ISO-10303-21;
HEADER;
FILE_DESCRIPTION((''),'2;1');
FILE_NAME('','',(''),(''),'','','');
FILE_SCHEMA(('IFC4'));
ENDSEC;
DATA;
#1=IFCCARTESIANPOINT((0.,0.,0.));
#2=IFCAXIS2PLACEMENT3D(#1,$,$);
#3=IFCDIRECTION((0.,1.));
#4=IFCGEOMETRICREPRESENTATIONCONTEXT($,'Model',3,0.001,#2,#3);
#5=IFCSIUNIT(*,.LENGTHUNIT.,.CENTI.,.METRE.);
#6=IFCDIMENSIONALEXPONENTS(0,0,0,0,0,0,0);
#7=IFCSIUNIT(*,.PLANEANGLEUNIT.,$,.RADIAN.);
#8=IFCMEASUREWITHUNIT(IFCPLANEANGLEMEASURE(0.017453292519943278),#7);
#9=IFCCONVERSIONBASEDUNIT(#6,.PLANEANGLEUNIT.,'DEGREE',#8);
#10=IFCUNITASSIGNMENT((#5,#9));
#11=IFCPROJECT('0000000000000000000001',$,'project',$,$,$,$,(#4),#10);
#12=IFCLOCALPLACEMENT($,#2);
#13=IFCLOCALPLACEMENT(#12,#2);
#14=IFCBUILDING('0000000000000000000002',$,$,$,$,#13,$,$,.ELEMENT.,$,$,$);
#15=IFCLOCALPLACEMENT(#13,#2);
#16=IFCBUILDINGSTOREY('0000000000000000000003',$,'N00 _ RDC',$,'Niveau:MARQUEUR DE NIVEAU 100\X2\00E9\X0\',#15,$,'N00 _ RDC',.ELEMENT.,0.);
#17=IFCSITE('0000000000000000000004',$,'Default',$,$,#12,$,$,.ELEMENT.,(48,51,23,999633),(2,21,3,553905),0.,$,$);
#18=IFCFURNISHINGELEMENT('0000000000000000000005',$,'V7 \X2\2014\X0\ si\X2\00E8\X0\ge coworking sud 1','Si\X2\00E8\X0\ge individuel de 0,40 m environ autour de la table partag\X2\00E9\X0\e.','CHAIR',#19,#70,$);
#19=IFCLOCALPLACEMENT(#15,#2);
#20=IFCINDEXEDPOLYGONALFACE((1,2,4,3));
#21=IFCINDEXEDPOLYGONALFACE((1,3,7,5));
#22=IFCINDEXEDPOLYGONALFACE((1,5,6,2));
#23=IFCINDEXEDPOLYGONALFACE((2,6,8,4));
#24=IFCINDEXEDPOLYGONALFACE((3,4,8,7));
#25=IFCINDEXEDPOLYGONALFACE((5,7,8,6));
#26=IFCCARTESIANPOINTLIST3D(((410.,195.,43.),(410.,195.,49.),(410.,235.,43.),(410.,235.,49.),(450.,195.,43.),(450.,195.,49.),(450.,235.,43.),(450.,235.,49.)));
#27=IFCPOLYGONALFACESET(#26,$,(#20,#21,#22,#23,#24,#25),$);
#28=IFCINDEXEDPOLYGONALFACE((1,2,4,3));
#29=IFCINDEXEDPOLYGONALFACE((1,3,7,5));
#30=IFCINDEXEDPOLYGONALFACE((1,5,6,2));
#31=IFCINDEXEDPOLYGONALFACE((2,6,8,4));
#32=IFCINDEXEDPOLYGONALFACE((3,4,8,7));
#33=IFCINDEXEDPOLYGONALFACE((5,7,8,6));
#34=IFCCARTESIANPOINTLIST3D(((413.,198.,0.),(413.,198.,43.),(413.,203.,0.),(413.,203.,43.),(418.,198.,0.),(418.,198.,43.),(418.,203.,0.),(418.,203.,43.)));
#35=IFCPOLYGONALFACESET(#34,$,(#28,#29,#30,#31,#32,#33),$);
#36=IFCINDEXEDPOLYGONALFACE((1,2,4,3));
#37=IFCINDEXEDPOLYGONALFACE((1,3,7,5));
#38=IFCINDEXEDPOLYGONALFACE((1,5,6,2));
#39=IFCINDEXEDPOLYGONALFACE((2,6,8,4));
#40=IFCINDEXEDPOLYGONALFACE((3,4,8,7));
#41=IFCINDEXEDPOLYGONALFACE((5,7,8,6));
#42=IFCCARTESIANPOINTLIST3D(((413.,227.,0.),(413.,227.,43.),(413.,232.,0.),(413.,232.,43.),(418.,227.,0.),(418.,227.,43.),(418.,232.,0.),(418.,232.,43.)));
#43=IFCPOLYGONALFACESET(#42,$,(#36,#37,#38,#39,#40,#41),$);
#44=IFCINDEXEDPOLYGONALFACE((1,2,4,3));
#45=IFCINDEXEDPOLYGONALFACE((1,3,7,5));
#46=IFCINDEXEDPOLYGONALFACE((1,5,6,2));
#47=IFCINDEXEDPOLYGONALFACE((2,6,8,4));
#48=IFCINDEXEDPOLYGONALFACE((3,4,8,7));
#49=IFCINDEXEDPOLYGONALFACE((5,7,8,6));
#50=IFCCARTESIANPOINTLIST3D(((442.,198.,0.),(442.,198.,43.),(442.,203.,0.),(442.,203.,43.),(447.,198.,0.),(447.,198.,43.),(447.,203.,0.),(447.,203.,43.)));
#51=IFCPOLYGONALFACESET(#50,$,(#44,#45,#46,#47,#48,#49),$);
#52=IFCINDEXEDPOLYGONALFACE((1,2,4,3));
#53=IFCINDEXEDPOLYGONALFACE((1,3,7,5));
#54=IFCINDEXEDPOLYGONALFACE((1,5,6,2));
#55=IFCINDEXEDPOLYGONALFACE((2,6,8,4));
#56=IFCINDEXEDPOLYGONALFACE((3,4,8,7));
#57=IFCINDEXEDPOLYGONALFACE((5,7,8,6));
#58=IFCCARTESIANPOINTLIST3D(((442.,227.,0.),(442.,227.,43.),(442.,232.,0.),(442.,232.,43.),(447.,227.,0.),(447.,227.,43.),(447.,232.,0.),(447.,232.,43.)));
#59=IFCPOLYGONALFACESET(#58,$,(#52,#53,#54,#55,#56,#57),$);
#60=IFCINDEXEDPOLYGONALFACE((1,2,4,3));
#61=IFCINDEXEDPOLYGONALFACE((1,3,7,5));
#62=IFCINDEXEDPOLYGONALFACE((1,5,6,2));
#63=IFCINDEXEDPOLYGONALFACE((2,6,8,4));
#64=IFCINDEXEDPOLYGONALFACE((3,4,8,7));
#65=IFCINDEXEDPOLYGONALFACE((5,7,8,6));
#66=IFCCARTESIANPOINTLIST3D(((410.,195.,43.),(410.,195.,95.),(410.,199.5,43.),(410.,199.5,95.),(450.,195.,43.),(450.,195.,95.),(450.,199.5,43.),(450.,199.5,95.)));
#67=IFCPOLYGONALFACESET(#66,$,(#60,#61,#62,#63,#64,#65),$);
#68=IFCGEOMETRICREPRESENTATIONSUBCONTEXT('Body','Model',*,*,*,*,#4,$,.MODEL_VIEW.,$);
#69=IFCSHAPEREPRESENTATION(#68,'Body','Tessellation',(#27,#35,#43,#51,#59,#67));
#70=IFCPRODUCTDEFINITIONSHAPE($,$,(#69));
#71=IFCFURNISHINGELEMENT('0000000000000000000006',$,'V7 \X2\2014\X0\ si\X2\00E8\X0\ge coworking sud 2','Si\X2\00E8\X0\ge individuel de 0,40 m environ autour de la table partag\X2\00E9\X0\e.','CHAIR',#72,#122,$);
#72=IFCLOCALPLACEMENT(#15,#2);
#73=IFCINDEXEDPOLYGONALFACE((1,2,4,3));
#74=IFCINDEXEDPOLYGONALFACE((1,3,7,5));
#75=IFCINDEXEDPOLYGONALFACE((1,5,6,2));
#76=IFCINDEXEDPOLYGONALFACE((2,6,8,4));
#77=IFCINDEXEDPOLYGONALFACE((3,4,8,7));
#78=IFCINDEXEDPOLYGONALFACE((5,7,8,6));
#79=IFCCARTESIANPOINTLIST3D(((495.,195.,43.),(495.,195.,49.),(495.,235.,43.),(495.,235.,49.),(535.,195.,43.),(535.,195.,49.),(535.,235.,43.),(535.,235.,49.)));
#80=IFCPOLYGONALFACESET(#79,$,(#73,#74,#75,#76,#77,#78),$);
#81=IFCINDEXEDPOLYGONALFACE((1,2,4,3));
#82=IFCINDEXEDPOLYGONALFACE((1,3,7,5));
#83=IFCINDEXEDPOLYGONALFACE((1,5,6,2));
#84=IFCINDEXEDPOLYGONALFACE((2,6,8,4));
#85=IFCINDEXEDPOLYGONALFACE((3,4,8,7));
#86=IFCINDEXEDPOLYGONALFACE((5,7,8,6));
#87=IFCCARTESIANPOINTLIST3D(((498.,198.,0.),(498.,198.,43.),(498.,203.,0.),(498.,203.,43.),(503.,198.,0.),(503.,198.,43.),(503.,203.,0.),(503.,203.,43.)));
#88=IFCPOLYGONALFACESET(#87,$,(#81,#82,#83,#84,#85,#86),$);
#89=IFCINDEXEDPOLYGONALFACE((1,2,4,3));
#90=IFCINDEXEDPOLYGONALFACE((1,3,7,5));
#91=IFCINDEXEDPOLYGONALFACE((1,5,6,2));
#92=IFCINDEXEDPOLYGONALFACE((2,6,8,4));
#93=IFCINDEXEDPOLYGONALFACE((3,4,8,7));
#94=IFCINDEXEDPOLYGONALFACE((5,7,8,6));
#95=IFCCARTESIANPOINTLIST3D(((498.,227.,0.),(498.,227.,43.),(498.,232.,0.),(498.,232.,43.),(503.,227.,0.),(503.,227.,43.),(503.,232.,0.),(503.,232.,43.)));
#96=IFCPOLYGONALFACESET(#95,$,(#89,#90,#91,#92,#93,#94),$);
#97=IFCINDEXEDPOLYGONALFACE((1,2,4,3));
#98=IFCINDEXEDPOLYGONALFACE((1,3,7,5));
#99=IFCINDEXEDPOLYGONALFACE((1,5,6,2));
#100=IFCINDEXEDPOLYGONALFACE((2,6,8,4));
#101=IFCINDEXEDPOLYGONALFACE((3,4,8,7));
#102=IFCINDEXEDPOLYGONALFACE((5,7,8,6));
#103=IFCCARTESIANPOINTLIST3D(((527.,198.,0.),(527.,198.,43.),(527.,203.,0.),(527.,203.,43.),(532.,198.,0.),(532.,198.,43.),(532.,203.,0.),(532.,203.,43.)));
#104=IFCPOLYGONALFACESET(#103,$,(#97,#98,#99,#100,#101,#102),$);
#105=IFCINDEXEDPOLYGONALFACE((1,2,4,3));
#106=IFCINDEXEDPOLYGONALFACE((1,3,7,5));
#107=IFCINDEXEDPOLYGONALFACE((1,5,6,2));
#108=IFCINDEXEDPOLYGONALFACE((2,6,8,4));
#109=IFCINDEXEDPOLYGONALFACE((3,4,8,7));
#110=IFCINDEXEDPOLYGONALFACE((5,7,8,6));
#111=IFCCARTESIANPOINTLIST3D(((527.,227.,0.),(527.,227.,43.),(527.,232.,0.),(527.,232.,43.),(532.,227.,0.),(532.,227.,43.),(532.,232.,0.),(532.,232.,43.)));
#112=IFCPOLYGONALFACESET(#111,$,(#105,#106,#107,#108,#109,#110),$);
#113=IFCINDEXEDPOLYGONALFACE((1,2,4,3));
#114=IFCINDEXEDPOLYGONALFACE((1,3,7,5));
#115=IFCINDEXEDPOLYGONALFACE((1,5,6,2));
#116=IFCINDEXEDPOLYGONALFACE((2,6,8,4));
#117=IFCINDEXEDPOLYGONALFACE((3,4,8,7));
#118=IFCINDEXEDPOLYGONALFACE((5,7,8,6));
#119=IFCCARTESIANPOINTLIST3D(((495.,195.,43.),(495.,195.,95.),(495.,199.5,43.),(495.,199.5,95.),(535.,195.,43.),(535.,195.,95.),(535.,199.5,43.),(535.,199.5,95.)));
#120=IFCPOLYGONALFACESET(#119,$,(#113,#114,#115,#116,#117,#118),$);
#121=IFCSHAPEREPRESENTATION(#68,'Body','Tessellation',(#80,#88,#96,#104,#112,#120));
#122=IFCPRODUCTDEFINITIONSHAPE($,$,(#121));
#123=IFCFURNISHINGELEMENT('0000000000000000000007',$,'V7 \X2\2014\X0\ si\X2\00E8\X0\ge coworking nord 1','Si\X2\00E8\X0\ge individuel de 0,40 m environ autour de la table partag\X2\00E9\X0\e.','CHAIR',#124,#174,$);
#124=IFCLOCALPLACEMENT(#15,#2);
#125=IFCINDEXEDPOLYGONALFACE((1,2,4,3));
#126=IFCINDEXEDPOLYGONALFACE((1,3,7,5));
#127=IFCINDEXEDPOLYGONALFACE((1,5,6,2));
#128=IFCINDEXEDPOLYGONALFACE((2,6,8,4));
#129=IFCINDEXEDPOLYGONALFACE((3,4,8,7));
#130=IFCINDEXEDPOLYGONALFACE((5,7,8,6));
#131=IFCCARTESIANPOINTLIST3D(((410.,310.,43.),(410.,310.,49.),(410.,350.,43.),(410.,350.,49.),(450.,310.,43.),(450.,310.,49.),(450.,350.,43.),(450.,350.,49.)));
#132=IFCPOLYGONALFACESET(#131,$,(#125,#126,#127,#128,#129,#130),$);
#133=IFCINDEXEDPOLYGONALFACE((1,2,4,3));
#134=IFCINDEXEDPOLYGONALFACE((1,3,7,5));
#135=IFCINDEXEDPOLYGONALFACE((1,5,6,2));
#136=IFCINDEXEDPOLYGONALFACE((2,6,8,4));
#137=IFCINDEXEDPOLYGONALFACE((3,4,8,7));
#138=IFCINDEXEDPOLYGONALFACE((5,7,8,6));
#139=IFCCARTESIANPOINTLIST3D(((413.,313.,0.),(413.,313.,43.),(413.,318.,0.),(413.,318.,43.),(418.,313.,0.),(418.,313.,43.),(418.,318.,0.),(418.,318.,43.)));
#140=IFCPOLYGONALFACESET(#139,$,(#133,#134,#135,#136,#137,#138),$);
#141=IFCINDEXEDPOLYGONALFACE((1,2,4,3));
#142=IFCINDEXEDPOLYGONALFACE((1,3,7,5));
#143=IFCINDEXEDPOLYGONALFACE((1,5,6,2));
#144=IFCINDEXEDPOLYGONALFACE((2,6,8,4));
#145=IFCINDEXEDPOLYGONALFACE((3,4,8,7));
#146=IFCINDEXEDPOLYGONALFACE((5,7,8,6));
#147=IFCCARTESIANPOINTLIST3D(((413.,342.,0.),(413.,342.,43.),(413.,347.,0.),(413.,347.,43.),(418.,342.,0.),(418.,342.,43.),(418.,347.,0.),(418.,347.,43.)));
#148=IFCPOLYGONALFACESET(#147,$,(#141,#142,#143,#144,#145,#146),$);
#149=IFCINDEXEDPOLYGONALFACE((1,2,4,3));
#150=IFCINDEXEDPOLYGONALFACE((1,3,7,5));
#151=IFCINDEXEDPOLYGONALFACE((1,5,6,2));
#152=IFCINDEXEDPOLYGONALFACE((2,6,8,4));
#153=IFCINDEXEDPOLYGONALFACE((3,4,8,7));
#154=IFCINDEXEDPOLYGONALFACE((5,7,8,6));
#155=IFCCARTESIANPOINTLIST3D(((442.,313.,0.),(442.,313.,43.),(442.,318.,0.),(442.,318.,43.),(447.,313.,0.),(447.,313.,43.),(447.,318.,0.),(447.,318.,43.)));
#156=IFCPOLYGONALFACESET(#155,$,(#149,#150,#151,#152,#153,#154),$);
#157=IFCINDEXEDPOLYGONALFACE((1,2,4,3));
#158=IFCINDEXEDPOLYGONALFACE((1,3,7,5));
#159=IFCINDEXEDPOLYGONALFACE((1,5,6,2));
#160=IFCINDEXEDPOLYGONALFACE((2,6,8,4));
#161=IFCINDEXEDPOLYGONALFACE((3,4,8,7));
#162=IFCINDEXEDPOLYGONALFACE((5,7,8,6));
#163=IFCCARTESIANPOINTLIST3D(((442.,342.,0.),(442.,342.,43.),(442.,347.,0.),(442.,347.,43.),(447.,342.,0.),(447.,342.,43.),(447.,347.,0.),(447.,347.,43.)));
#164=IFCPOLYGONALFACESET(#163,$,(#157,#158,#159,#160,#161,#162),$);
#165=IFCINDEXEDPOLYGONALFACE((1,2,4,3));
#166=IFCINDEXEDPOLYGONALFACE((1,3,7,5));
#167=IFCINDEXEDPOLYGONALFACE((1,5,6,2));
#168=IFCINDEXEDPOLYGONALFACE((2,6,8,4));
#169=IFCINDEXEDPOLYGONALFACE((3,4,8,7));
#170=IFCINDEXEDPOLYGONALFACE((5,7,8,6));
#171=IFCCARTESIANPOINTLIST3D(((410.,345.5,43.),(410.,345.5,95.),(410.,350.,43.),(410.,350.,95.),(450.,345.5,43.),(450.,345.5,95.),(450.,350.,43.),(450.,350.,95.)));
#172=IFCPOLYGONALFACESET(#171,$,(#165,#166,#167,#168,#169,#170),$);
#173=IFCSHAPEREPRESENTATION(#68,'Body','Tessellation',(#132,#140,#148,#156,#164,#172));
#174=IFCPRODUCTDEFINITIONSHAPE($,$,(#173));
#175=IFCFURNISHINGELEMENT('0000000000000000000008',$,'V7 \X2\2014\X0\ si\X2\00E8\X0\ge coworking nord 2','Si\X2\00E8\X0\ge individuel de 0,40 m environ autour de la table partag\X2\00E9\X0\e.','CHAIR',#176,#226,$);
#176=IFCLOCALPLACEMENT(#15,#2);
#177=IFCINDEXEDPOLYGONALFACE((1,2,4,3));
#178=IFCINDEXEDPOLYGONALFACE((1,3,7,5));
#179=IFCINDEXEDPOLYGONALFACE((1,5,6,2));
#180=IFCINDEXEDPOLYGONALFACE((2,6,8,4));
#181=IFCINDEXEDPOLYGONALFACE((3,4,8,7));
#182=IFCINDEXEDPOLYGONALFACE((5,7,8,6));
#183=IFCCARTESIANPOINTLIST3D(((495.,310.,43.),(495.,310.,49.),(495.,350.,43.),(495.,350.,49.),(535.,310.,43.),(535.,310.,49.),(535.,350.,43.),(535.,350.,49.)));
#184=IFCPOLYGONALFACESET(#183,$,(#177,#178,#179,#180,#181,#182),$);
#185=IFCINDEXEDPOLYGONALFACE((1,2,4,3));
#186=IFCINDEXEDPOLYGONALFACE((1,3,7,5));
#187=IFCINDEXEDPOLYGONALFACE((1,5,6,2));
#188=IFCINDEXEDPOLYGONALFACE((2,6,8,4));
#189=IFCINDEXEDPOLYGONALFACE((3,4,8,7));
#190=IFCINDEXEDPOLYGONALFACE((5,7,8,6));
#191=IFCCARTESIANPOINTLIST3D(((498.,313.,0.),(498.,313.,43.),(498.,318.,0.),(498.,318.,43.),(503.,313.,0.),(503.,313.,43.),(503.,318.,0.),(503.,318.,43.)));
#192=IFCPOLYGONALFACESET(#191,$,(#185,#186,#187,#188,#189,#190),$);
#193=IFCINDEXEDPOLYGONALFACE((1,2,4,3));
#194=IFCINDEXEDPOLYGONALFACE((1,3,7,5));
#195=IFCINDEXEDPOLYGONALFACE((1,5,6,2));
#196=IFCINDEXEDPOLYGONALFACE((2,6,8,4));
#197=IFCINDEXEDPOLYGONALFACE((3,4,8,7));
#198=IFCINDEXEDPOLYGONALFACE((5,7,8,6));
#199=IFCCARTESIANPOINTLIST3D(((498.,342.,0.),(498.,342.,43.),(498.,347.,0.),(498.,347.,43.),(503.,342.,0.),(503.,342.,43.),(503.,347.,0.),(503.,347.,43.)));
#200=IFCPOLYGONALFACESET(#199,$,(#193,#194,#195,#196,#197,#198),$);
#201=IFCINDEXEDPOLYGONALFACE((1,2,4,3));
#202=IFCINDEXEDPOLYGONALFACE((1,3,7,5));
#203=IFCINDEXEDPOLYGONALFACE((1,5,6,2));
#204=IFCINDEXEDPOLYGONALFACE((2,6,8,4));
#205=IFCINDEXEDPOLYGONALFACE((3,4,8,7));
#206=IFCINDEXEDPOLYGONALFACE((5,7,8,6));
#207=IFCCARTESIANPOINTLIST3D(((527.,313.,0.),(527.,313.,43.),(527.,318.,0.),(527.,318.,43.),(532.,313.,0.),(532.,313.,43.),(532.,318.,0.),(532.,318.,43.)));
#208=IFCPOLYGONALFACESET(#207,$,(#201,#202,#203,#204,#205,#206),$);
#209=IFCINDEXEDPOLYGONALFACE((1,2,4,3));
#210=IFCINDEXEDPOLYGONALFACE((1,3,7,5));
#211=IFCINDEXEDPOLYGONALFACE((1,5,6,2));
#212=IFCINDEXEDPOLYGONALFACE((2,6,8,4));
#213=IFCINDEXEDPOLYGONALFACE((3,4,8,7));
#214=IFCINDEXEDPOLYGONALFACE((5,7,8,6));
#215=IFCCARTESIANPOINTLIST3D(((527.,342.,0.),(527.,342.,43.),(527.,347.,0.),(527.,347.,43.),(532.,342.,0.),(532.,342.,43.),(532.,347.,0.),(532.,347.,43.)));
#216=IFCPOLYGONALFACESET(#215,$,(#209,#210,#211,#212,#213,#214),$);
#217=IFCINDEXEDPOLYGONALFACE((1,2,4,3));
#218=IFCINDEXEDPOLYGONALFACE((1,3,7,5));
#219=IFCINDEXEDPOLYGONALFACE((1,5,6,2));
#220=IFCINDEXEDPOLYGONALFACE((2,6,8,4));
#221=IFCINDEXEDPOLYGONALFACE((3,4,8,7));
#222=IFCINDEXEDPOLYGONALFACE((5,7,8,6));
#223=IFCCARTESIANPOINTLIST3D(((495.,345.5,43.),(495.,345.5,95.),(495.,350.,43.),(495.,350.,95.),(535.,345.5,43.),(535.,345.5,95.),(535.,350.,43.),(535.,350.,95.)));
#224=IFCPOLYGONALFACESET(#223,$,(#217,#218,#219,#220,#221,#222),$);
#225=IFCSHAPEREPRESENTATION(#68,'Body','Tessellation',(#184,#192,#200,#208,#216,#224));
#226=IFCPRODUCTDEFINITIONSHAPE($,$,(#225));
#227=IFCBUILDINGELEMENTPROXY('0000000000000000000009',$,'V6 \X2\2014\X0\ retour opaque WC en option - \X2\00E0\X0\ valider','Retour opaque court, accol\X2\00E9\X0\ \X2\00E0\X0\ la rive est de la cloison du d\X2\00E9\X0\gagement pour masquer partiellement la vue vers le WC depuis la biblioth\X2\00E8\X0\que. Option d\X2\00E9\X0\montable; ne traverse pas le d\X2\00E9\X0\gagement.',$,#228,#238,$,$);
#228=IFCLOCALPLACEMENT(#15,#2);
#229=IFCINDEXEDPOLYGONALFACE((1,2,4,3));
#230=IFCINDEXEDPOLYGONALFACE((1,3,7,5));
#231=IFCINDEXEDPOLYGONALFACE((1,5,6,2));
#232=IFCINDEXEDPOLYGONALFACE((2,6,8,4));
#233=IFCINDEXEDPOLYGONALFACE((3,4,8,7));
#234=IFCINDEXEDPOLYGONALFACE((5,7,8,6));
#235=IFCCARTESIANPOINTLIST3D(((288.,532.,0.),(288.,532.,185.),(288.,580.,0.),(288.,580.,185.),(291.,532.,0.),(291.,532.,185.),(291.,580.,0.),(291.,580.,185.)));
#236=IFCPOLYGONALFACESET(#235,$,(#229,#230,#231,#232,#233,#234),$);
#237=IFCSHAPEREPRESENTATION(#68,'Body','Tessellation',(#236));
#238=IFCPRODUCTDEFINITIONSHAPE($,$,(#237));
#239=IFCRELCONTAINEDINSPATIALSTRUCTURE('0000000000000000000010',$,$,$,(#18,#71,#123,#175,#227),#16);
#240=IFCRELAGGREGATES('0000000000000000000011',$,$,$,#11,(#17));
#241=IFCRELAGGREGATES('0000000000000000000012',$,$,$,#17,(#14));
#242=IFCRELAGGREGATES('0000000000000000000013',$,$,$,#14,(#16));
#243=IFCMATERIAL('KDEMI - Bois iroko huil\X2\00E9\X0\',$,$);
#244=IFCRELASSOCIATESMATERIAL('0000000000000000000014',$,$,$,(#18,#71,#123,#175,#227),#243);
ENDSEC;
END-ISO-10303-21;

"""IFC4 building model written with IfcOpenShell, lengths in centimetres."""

from ifc_helpers import new_model, entity, si_unit, converted_unit, direction, frame, frame_2d, origin, origin_with_axes, place, context, subcontext, project, spatial, rectangle, extrude, material, element, save


model = new_model("IFC4")

# Units and contexts
model_context = context("Model", 3, precision=0.001, world=origin(), true_north=direction((0.0, 1.0)))
body_context = subcontext(model_context, "Body", "Model", "MODEL_VIEW")
ifc_project = project(units=[si_unit("LENGTHUNIT", "METRE", prefix="CENTI"), converted_unit("PLANEANGLEUNIT", "DEGREE", entity("IfcPlaneAngleMeasure", 0.017453292519943278), si_unit("PLANEANGLEUNIT", "RADIAN"), dimensions=[0, 0, 0, 0, 0, 0, 0])], contexts=[model_context])

# Site, building, storey
site_placement = place(None, origin())
site = spatial("IfcSite", under=ifc_project, at=site_placement, Name="Default", CompositionType="ELEMENT", RefLatitude=(48, 51, 23, 999633), RefLongitude=(2, 21, 3, 553905), RefElevation=0.0)
building_placement = place(site_placement, origin())
building = spatial("IfcBuilding", under=site, at=building_placement, CompositionType="ELEMENT")
storey_placement = place(building_placement, origin())
storey = spatial("IfcBuildingStorey", under=building, at=storey_placement, Name="N00 _ RDC", ObjectType="Niveau:MARQUEUR DE NIVEAU 100é", LongName="N00 _ RDC", CompositionType="ELEMENT", Elevation=0.0)

# Shared definitions
ifc_material_1 = material(Name="KDEMI - Bois iroko huilé")

# Furnishing elements
furnishing_1_placement = place(storey_placement, origin_with_axes())
element("IfcFurnishingElement", 1, at=furnishing_1_placement, inside=storey, material=ifc_material_1, Name="V7 — siège coworking sud 1", Description="Siège individuel de 0,40 m environ autour de la table partagée.", ObjectType="CHAIR", context=body_context, shape_type="SweptSolid", body=[
    extrude(rectangle(XDim=40.0, YDim=40.0, at=frame_2d((430.0, 215.0))), frame((0.0, 0.0, 43.0)), (0.0, 0.0, 1.0), 6.0),
    extrude(rectangle(XDim=5.0, YDim=5.0, at=frame_2d((415.5, 200.5))), origin(), (0.0, 0.0, 1.0), 43.0),
    extrude(rectangle(XDim=5.0, YDim=5.0, at=frame_2d((415.5, 229.5))), origin(), (0.0, 0.0, 1.0), 43.0),
    extrude(rectangle(XDim=5.0, YDim=5.0, at=frame_2d((444.5, 200.5))), origin(), (0.0, 0.0, 1.0), 43.0),
    extrude(rectangle(XDim=5.0, YDim=5.0, at=frame_2d((444.5, 229.5))), origin(), (0.0, 0.0, 1.0), 43.0),
    extrude(rectangle(XDim=40.0, YDim=4.5, at=frame_2d((430.0, 197.25))), frame((0.0, 0.0, 43.0)), (0.0, 0.0, 1.0), 52.0),
])
furnishing_2_placement = place(storey_placement, origin_with_axes())
element("IfcFurnishingElement", 2, at=furnishing_2_placement, inside=storey, material=ifc_material_1, Name="V7 — siège coworking sud 2", Description="Siège individuel de 0,40 m environ autour de la table partagée.", ObjectType="CHAIR", context=body_context, shape_type="SweptSolid", body=[
    extrude(rectangle(XDim=40.0, YDim=40.0, at=frame_2d((515.0, 215.0))), frame((0.0, 0.0, 43.0)), (0.0, 0.0, 1.0), 6.0),
    extrude(rectangle(XDim=5.0, YDim=5.0, at=frame_2d((500.5, 200.5))), origin(), (0.0, 0.0, 1.0), 43.0),
    extrude(rectangle(XDim=5.0, YDim=5.0, at=frame_2d((500.5, 229.5))), origin(), (0.0, 0.0, 1.0), 43.0),
    extrude(rectangle(XDim=5.0, YDim=5.0, at=frame_2d((529.5, 200.5))), origin(), (0.0, 0.0, 1.0), 43.0),
    extrude(rectangle(XDim=5.0, YDim=5.0, at=frame_2d((529.5, 229.5))), origin(), (0.0, 0.0, 1.0), 43.0),
    extrude(rectangle(XDim=40.0, YDim=4.5, at=frame_2d((515.0, 197.25))), frame((0.0, 0.0, 43.0)), (0.0, 0.0, 1.0), 52.0),
])
furnishing_3_placement = place(storey_placement, origin_with_axes())
element("IfcFurnishingElement", 3, at=furnishing_3_placement, inside=storey, material=ifc_material_1, Name="V7 — siège coworking nord 1", Description="Siège individuel de 0,40 m environ autour de la table partagée.", ObjectType="CHAIR", context=body_context, shape_type="SweptSolid", body=[
    extrude(rectangle(XDim=40.0, YDim=40.0, at=frame_2d((430.0, 330.0))), frame((0.0, 0.0, 43.0)), (0.0, 0.0, 1.0), 6.0),
    extrude(rectangle(XDim=5.0, YDim=5.0, at=frame_2d((415.5, 315.5))), origin(), (0.0, 0.0, 1.0), 43.0),
    extrude(rectangle(XDim=5.0, YDim=5.0, at=frame_2d((415.5, 344.5))), origin(), (0.0, 0.0, 1.0), 43.0),
    extrude(rectangle(XDim=5.0, YDim=5.0, at=frame_2d((444.5, 315.5))), origin(), (0.0, 0.0, 1.0), 43.0),
    extrude(rectangle(XDim=5.0, YDim=5.0, at=frame_2d((444.5, 344.5))), origin(), (0.0, 0.0, 1.0), 43.0),
    extrude(rectangle(XDim=40.0, YDim=4.5, at=frame_2d((430.0, 347.75))), frame((0.0, 0.0, 43.0)), (0.0, 0.0, 1.0), 52.0),
])
furnishing_4_placement = place(storey_placement, origin_with_axes())
element("IfcFurnishingElement", 4, at=furnishing_4_placement, inside=storey, material=ifc_material_1, Name="V7 — siège coworking nord 2", Description="Siège individuel de 0,40 m environ autour de la table partagée.", ObjectType="CHAIR", context=body_context, shape_type="SweptSolid", body=[
    extrude(rectangle(XDim=40.0, YDim=40.0, at=frame_2d((515.0, 330.0))), frame((0.0, 0.0, 43.0)), (0.0, 0.0, 1.0), 6.0),
    extrude(rectangle(XDim=5.0, YDim=5.0, at=frame_2d((500.5, 315.5))), origin(), (0.0, 0.0, 1.0), 43.0),
    extrude(rectangle(XDim=5.0, YDim=5.0, at=frame_2d((500.5, 344.5))), origin(), (0.0, 0.0, 1.0), 43.0),
    extrude(rectangle(XDim=5.0, YDim=5.0, at=frame_2d((529.5, 315.5))), origin(), (0.0, 0.0, 1.0), 43.0),
    extrude(rectangle(XDim=5.0, YDim=5.0, at=frame_2d((529.5, 344.5))), origin(), (0.0, 0.0, 1.0), 43.0),
    extrude(rectangle(XDim=40.0, YDim=4.5, at=frame_2d((515.0, 347.75))), frame((0.0, 0.0, 43.0)), (0.0, 0.0, 1.0), 52.0),
])

# Building element proxy
proxy_placement = place(storey_placement, origin_with_axes())
element("IfcBuildingElementProxy", 5, at=proxy_placement, inside=storey, material=ifc_material_1, Name="V6 — retour opaque WC en option - à valider", Description="Retour opaque court, accolé à la rive est de la cloison du dégagement pour masquer partiellement la vue vers le WC depuis la bibliothèque. Option démontable; ne traverse pas le dégagement.", context=body_context, shape_type="SweptSolid", body=[
    extrude(rectangle(XDim=3.0, YDim=48.0, at=frame_2d((289.5, 556.0))), origin(), (0.0, 0.0, 1.0), 185.0),
])

save(model, "model.ifc")
